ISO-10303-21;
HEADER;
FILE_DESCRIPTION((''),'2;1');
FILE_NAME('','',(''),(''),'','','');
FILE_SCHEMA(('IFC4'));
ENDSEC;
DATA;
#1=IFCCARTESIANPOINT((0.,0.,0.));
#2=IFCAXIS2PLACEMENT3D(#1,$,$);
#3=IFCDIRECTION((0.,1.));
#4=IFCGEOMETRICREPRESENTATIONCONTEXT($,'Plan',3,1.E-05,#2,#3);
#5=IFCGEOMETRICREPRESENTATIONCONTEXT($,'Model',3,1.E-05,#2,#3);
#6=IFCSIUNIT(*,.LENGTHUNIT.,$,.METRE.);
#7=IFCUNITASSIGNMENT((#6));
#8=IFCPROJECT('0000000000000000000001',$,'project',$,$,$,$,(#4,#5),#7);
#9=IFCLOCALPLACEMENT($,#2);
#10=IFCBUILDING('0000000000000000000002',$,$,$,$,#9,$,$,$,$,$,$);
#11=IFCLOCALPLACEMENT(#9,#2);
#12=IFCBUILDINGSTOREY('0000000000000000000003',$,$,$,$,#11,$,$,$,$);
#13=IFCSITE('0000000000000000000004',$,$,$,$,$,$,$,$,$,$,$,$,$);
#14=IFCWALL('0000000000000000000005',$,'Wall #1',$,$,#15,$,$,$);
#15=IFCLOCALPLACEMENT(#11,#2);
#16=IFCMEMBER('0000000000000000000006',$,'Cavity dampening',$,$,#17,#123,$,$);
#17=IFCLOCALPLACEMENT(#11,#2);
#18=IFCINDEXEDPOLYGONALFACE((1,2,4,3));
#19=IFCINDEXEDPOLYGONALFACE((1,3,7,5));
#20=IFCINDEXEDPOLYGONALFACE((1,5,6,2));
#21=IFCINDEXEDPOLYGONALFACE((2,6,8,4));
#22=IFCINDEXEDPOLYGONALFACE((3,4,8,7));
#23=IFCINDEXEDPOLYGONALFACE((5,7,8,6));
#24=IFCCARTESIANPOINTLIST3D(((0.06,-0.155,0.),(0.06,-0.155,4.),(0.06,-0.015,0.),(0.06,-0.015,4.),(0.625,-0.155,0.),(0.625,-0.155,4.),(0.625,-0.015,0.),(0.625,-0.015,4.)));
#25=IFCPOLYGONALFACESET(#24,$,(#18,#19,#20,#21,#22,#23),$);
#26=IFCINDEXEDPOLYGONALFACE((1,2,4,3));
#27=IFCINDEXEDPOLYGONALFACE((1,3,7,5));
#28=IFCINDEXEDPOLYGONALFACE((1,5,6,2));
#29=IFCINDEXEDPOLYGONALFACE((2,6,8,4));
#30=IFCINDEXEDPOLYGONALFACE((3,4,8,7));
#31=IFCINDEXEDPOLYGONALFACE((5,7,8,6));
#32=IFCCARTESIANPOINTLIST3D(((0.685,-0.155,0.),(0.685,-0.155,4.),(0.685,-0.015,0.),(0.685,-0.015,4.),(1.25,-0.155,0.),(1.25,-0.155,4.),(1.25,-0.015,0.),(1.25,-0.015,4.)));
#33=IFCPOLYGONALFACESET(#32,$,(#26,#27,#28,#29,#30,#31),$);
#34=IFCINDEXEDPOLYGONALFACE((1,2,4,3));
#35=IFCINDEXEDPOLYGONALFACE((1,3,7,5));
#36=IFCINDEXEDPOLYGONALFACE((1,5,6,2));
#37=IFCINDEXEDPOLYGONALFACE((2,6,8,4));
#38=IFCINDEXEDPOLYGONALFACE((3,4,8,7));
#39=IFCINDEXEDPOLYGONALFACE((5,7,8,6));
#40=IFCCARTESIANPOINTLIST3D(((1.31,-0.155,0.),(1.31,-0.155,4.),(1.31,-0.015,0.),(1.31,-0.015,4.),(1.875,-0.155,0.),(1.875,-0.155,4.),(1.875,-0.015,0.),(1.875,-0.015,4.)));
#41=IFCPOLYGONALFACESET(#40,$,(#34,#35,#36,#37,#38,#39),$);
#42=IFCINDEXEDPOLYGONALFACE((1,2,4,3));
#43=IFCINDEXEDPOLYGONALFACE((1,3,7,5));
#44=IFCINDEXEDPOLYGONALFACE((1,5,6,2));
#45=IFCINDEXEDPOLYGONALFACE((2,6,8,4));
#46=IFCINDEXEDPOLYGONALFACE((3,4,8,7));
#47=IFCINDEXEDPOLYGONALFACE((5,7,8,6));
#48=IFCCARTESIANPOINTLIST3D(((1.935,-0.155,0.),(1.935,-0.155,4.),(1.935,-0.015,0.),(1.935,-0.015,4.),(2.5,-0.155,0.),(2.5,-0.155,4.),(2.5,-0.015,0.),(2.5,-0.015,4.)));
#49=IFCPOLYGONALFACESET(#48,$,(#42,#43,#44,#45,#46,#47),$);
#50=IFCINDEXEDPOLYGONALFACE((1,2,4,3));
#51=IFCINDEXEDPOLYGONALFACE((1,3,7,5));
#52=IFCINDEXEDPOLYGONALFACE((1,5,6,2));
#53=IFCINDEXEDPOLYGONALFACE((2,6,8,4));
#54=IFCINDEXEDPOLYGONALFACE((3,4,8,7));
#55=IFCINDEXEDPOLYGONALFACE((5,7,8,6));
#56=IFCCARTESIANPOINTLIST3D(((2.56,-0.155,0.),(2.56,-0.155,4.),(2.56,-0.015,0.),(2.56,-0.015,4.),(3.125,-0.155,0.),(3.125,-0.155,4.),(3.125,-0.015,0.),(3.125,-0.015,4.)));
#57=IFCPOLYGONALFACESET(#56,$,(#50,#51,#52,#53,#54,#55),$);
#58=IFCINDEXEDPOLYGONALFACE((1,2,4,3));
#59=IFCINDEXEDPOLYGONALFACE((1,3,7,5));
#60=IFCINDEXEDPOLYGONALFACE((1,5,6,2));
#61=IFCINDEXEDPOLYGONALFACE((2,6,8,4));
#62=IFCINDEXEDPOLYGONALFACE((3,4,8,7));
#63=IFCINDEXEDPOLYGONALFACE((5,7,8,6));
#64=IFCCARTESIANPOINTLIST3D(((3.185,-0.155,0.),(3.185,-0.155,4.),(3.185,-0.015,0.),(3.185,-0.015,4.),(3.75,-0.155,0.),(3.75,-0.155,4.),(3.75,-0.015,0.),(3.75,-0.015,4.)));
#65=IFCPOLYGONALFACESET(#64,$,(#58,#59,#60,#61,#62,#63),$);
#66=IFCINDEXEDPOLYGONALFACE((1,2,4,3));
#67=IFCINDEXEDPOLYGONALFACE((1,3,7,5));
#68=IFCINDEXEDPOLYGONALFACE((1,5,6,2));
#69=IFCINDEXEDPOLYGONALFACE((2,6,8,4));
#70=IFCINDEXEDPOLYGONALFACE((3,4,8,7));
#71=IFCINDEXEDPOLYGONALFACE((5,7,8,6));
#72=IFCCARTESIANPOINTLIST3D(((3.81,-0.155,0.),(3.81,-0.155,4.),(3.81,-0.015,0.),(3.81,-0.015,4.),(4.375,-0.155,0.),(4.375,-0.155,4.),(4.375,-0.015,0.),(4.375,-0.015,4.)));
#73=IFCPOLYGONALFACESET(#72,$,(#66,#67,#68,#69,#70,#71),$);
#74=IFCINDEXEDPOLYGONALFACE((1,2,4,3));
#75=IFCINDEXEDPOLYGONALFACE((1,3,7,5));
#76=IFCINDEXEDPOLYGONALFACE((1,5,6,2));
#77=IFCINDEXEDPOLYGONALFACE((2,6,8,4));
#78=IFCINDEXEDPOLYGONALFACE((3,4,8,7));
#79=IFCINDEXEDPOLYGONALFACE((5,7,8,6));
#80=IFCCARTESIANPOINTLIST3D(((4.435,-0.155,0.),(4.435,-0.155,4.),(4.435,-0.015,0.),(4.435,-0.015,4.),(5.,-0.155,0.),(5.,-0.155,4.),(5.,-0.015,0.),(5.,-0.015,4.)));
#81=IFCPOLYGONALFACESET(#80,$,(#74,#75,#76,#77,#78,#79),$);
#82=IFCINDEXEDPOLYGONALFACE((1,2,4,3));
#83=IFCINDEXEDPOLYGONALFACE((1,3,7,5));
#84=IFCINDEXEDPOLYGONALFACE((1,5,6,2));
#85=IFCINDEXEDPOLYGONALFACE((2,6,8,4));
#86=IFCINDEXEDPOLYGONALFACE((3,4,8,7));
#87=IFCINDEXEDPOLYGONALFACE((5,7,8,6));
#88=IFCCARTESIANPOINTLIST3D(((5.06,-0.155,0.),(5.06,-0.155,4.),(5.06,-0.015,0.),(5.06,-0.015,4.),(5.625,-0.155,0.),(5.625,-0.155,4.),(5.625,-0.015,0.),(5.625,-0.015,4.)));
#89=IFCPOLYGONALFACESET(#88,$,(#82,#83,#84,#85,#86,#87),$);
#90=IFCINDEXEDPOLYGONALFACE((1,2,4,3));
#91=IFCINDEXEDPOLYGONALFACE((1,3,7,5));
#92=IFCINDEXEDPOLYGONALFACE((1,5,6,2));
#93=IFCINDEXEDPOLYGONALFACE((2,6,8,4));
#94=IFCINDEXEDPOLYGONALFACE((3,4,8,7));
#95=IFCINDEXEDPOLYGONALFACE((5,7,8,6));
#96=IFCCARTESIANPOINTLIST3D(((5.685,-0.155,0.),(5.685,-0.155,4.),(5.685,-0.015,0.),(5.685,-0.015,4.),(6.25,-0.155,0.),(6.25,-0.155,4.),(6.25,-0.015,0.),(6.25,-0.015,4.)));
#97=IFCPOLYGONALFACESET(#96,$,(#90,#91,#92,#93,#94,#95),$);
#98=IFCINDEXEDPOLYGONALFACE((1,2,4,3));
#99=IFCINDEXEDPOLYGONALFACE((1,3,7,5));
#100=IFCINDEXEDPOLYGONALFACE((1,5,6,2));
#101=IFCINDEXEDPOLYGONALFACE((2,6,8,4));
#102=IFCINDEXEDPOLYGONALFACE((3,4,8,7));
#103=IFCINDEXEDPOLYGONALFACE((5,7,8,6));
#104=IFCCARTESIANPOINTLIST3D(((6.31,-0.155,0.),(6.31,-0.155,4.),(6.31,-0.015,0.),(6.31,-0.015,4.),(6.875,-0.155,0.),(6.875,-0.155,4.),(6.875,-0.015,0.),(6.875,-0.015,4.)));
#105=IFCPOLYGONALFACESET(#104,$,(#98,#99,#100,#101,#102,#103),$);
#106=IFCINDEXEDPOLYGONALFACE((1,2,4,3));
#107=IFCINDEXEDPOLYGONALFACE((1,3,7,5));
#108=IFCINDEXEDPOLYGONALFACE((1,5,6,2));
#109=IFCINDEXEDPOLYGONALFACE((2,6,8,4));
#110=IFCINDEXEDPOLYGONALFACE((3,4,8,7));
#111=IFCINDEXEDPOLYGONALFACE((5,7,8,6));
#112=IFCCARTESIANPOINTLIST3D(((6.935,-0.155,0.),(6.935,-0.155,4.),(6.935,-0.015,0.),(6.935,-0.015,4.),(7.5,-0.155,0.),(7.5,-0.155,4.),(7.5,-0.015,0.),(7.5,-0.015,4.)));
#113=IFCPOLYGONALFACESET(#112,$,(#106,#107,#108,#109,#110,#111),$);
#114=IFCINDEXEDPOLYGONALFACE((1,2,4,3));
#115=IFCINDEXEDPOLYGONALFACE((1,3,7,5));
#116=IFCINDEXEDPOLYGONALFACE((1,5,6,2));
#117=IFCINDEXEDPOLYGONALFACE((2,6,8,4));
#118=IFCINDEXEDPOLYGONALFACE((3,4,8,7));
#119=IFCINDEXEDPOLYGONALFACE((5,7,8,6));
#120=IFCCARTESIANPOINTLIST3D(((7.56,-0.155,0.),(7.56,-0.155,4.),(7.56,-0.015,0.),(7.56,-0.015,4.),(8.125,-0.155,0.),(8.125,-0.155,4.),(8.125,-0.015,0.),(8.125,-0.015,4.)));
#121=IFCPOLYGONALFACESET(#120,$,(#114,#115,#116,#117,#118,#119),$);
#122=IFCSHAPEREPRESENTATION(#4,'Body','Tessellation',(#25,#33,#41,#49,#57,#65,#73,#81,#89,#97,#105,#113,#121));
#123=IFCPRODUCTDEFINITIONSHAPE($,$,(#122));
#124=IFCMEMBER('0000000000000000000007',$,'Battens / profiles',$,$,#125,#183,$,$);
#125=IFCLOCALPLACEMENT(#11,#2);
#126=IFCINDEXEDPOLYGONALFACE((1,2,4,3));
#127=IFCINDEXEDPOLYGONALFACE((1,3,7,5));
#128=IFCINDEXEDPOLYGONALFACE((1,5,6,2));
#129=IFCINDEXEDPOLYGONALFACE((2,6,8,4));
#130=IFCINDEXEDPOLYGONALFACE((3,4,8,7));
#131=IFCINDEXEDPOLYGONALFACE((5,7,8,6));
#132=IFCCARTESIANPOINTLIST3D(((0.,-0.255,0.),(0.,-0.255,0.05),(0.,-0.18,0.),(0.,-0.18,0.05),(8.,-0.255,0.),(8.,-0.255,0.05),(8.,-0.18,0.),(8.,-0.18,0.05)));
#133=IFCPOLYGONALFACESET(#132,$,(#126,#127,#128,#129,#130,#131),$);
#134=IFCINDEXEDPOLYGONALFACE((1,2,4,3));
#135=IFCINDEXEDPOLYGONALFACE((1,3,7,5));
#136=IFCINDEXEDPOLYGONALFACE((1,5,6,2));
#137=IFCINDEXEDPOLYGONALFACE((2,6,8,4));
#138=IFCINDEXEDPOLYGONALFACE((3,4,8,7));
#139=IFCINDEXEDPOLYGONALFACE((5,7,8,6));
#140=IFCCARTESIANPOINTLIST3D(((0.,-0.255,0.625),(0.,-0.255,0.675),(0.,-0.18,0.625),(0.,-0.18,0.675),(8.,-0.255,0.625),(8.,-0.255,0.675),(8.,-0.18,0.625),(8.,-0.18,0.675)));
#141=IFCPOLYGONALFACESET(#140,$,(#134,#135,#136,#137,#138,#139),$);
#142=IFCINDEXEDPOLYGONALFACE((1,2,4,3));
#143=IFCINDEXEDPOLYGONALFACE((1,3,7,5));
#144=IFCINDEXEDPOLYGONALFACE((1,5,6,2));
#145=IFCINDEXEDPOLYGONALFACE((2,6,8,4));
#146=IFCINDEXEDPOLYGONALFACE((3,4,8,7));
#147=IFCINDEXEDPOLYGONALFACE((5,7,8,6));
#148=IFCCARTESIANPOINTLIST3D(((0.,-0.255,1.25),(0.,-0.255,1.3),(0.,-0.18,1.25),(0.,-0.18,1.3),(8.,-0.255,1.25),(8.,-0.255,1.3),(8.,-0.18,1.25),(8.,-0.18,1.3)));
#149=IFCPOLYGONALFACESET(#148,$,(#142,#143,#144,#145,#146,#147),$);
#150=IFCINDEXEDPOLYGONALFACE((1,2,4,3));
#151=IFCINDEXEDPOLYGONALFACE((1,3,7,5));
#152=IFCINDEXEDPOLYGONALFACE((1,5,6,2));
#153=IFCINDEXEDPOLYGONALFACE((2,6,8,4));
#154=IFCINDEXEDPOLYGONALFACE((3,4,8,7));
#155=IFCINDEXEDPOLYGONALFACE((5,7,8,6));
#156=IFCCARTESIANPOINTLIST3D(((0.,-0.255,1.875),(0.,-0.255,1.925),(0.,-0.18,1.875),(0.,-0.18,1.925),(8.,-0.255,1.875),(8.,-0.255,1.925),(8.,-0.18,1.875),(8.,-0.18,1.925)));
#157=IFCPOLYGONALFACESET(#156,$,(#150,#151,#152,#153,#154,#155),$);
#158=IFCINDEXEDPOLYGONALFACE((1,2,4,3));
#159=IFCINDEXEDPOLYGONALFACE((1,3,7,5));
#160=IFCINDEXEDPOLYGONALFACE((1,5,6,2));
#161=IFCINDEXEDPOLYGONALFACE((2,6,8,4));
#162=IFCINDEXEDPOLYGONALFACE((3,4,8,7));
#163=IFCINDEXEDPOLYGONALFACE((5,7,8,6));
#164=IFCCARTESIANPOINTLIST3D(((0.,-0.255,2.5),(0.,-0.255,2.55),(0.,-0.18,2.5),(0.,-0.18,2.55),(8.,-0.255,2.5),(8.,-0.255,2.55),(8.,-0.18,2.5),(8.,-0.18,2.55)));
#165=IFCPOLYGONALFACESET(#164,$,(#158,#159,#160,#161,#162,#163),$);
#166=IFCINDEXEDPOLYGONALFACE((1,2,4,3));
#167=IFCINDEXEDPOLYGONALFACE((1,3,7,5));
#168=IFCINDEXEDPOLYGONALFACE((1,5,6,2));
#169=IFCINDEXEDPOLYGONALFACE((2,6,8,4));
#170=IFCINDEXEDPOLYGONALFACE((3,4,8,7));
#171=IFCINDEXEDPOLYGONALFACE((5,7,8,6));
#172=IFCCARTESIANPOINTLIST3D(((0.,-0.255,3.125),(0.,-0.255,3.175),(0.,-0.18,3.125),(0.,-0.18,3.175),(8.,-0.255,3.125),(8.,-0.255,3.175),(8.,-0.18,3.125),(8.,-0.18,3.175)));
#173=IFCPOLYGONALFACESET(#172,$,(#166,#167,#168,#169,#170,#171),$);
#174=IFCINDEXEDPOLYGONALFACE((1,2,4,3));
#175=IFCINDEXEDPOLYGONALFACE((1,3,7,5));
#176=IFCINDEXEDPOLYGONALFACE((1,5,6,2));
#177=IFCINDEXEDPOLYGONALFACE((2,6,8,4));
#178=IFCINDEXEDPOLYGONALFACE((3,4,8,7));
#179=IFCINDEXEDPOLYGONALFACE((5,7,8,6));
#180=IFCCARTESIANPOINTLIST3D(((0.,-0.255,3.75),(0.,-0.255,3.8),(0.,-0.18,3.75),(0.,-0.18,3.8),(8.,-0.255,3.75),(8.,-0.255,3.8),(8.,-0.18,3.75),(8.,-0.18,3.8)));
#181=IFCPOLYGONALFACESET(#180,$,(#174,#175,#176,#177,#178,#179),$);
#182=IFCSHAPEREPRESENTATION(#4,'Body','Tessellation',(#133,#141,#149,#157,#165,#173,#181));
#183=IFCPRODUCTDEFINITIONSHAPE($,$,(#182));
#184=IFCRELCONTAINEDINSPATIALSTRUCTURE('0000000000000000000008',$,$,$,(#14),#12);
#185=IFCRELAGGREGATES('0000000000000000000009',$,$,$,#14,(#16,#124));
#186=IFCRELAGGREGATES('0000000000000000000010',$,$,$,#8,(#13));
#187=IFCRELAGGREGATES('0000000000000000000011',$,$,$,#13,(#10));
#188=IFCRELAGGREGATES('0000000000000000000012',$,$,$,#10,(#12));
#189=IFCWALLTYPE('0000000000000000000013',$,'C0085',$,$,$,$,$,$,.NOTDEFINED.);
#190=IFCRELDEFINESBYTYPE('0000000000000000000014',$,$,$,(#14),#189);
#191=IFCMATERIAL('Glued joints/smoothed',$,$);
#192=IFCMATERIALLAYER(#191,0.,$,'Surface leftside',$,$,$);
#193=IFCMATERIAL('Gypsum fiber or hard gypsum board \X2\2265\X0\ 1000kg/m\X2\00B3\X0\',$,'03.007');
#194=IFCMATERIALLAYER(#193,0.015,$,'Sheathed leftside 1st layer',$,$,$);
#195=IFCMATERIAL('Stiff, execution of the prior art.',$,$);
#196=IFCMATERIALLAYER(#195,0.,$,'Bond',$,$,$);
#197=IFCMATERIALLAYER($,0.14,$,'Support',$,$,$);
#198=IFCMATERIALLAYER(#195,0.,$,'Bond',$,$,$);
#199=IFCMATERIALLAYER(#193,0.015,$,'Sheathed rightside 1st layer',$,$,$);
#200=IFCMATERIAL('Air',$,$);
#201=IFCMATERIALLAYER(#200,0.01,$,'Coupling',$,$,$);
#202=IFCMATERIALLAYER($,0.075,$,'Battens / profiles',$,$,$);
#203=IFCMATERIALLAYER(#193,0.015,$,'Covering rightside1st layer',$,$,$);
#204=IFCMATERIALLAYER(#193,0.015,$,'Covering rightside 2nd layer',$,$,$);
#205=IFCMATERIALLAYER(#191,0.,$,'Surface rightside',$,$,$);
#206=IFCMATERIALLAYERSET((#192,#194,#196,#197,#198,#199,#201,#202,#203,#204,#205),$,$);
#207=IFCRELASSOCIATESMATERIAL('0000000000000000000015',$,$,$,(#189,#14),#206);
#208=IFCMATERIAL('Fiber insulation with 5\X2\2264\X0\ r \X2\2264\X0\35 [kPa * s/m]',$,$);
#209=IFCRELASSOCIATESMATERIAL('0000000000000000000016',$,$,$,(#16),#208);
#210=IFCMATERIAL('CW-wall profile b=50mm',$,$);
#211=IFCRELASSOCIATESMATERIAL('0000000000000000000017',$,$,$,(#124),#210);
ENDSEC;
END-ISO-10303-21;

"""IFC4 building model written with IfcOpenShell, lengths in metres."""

from ifc_helpers import new_model, si_unit, direction, frame, frame_2d, origin, place, context, project, spatial, rectangle, extrude, material, layer, layer_set, type_object, element, aggregate, save


model = new_model("IFC4")

# Units and contexts
plan_context = context("Plan", 3, precision=1e-05, world=origin(), true_north=direction((0.0, 1.0)))
model_context = context("Model", 3, precision=1e-05, world=origin(), true_north=direction((0.0, 1.0)))
ifc_project = project(units=[si_unit("LENGTHUNIT", "METRE")], contexts=[plan_context, model_context])

# Site, building, storey
site = spatial("IfcSite", under=ifc_project)
building_placement = place(None, origin())
building = spatial("IfcBuilding", under=site, at=building_placement)
storey_placement = place(building_placement, origin())
storey = spatial("IfcBuildingStorey", under=building, at=storey_placement)

# Wall, members
ifc_material_1 = material(Name="Glued joints/smoothed")
ifc_layer_1 = layer(ifc_material_1, 0.0, Name="Surface leftside")
ifc_material_2 = material(Name="Gypsum fiber or hard gypsum board ≥ 1000kg/m³", Category="03.007")
ifc_layer_2 = layer(ifc_material_2, 0.015, Name="Sheathed leftside 1st layer")
ifc_material_3 = material(Name="Stiff, execution of the prior art.")
ifc_layer_3 = layer(ifc_material_3, 0.0, Name="Bond")
ifc_layer_4 = layer(None, 0.14, Name="Support")
ifc_layer_5 = layer(ifc_material_3, 0.0, Name="Bond")
ifc_layer_6 = layer(ifc_material_2, 0.015, Name="Sheathed rightside 1st layer")
ifc_material_4 = material(Name="Air")
ifc_layer_7 = layer(ifc_material_4, 0.01, Name="Coupling")
ifc_layer_8 = layer(None, 0.075, Name="Battens / profiles")
ifc_layer_9 = layer(ifc_material_2, 0.015, Name="Covering rightside1st layer")
ifc_layer_10 = layer(ifc_material_2, 0.015, Name="Covering rightside 2nd layer")
ifc_layer_11 = layer(ifc_material_1, 0.0, Name="Surface rightside")
ifc_layer_set = layer_set([ifc_layer_1, ifc_layer_2, ifc_layer_3, ifc_layer_4, ifc_layer_5, ifc_layer_6, ifc_layer_7, ifc_layer_8, ifc_layer_9, ifc_layer_10, ifc_layer_11])
wall_type = type_object("IfcWallType", Name="C0085", PredefinedType="NOTDEFINED", material=ifc_layer_set)
wall_placement = place(None, frame((0.0, 0.0, 0.0), z_axis=(0.0, -1.0, 0.0), x_axis=(1.0, 0.0, 0.0)))
wall = element("IfcWall", 1, at=wall_placement, inside=storey, type_object=wall_type, material=ifc_layer_set, Name="Wall #1")
ifc_material_5 = material(Name="Fiber insulation with 5≤ r ≤35 [kPa * s/m]")
member_1_placement = place(wall_placement, origin())
member_1 = element("IfcMember", 2, at=member_1_placement, material=ifc_material_5, Name="Cavity dampening", context=plan_context, shape_type="SweptSolid", body=[
    extrude(rectangle(XDim=0.565, YDim=0.14, at=frame_2d((0.2825, 0.07), x_axis=(1.0, 0.0))), frame((0.06, 4.0, 0.015), z_axis=(0.0, -1.0, 0.0), x_axis=(1.0, 0.0, 0.0)), (0.0, 0.0, 1.0), 4.0),
    extrude(rectangle(XDim=0.565, YDim=0.14, at=frame_2d((0.2825, 0.07), x_axis=(1.0, 0.0))), frame((0.685, 4.0, 0.015), z_axis=(0.0, -1.0, 0.0), x_axis=(1.0, 0.0, 0.0)), (0.0, 0.0, 1.0), 4.0),
    extrude(rectangle(XDim=0.565, YDim=0.14, at=frame_2d((0.2825, 0.07), x_axis=(1.0, 0.0))), frame((1.31, 4.0, 0.015), z_axis=(0.0, -1.0, 0.0), x_axis=(1.0, 0.0, 0.0)), (0.0, 0.0, 1.0), 4.0),
    extrude(rectangle(XDim=0.565, YDim=0.14, at=frame_2d((0.2825, 0.07), x_axis=(1.0, 0.0))), frame((1.935, 4.0, 0.015), z_axis=(0.0, -1.0, 0.0), x_axis=(1.0, 0.0, 0.0)), (0.0, 0.0, 1.0), 4.0),
    extrude(rectangle(XDim=0.565, YDim=0.14, at=frame_2d((0.2825, 0.07), x_axis=(1.0, 0.0))), frame((2.56, 4.0, 0.015), z_axis=(0.0, -1.0, 0.0), x_axis=(1.0, 0.0, 0.0)), (0.0, 0.0, 1.0), 4.0),
    extrude(rectangle(XDim=0.565, YDim=0.14, at=frame_2d((0.2825, 0.07), x_axis=(1.0, 0.0))), frame((3.185, 4.0, 0.015), z_axis=(0.0, -1.0, 0.0), x_axis=(1.0, 0.0, 0.0)), (0.0, 0.0, 1.0), 4.0),
    extrude(rectangle(XDim=0.565, YDim=0.14, at=frame_2d((0.2825, 0.07), x_axis=(1.0, 0.0))), frame((3.81, 4.0, 0.015), z_axis=(0.0, -1.0, 0.0), x_axis=(1.0, 0.0, 0.0)), (0.0, 0.0, 1.0), 4.0),
    extrude(rectangle(XDim=0.565, YDim=0.14, at=frame_2d((0.2825, 0.07), x_axis=(1.0, 0.0))), frame((4.435, 4.0, 0.015), z_axis=(0.0, -1.0, 0.0), x_axis=(1.0, 0.0, 0.0)), (0.0, 0.0, 1.0), 4.0),
    extrude(rectangle(XDim=0.565, YDim=0.14, at=frame_2d((0.2825, 0.07), x_axis=(1.0, 0.0))), frame((5.06, 4.0, 0.015), z_axis=(0.0, -1.0, 0.0), x_axis=(1.0, 0.0, 0.0)), (0.0, 0.0, 1.0), 4.0),
    extrude(rectangle(XDim=0.565, YDim=0.14, at=frame_2d((0.2825, 0.07), x_axis=(1.0, 0.0))), frame((5.685, 4.0, 0.015), z_axis=(0.0, -1.0, 0.0), x_axis=(1.0, 0.0, 0.0)), (0.0, 0.0, 1.0), 4.0),
    extrude(rectangle(XDim=0.565, YDim=0.14, at=frame_2d((0.2825, 0.07), x_axis=(1.0, 0.0))), frame((6.31, 4.0, 0.015), z_axis=(0.0, -1.0, 0.0), x_axis=(1.0, 0.0, 0.0)), (0.0, 0.0, 1.0), 4.0),
    extrude(rectangle(XDim=0.565, YDim=0.14, at=frame_2d((0.2825, 0.07), x_axis=(1.0, 0.0))), frame((6.935, 4.0, 0.015), z_axis=(0.0, -1.0, 0.0), x_axis=(1.0, 0.0, 0.0)), (0.0, 0.0, 1.0), 4.0),
    extrude(rectangle(XDim=0.565, YDim=0.14, at=frame_2d((0.2825, 0.07), x_axis=(1.0, 0.0))), frame((7.56, 4.0, 0.015), z_axis=(0.0, -1.0, 0.0), x_axis=(1.0, 0.0, 0.0)), (0.0, 0.0, 1.0), 4.0),
])
ifc_material_6 = material(Name="CW-wall profile b=50mm")
member_2_placement = place(wall_placement, origin())
member_2 = element("IfcMember", 3, at=member_2_placement, material=ifc_material_6, Name="Battens / profiles", context=plan_context, shape_type="SweptSolid", body=[
    extrude(rectangle(XDim=0.05, YDim=0.075, at=frame_2d((0.025, 0.0375), x_axis=(1.0, 0.0))), frame((0.0, 0.0, 0.18), z_axis=(1.0, 0.0, 0.0), x_axis=(0.0, 1.0, 0.0)), (0.0, 0.0, 1.0), 8.0),
    extrude(rectangle(XDim=0.05, YDim=0.075, at=frame_2d((0.025, 0.0375), x_axis=(1.0, 0.0))), frame((0.0, 0.625, 0.18), z_axis=(1.0, 0.0, 0.0), x_axis=(0.0, 1.0, 0.0)), (0.0, 0.0, 1.0), 8.0),
    extrude(rectangle(XDim=0.05, YDim=0.075, at=frame_2d((0.025, 0.0375), x_axis=(1.0, 0.0))), frame((0.0, 1.25, 0.18), z_axis=(1.0, 0.0, 0.0), x_axis=(0.0, 1.0, 0.0)), (0.0, 0.0, 1.0), 8.0),
    extrude(rectangle(XDim=0.05, YDim=0.075, at=frame_2d((0.025, 0.0375), x_axis=(1.0, 0.0))), frame((0.0, 1.875, 0.18), z_axis=(1.0, 0.0, 0.0), x_axis=(0.0, 1.0, 0.0)), (0.0, 0.0, 1.0), 8.0),
    extrude(rectangle(XDim=0.05, YDim=0.075, at=frame_2d((0.025, 0.0375), x_axis=(1.0, 0.0))), frame((0.0, 2.5, 0.18), z_axis=(1.0, 0.0, 0.0), x_axis=(0.0, 1.0, 0.0)), (0.0, 0.0, 1.0), 8.0),
    extrude(rectangle(XDim=0.05, YDim=0.075, at=frame_2d((0.025, 0.0375), x_axis=(1.0, 0.0))), frame((0.0, 3.125, 0.18), z_axis=(1.0, 0.0, 0.0), x_axis=(0.0, 1.0, 0.0)), (0.0, 0.0, 1.0), 8.0),
    extrude(rectangle(XDim=0.05, YDim=0.075, at=frame_2d((0.025, 0.0375), x_axis=(1.0, 0.0))), frame((0.0, 3.75, 0.18), z_axis=(1.0, 0.0, 0.0), x_axis=(0.0, 1.0, 0.0)), (0.0, 0.0, 1.0), 8.0),
])
aggregate(wall, [member_1, member_2])

save(model, "model.ifc")
